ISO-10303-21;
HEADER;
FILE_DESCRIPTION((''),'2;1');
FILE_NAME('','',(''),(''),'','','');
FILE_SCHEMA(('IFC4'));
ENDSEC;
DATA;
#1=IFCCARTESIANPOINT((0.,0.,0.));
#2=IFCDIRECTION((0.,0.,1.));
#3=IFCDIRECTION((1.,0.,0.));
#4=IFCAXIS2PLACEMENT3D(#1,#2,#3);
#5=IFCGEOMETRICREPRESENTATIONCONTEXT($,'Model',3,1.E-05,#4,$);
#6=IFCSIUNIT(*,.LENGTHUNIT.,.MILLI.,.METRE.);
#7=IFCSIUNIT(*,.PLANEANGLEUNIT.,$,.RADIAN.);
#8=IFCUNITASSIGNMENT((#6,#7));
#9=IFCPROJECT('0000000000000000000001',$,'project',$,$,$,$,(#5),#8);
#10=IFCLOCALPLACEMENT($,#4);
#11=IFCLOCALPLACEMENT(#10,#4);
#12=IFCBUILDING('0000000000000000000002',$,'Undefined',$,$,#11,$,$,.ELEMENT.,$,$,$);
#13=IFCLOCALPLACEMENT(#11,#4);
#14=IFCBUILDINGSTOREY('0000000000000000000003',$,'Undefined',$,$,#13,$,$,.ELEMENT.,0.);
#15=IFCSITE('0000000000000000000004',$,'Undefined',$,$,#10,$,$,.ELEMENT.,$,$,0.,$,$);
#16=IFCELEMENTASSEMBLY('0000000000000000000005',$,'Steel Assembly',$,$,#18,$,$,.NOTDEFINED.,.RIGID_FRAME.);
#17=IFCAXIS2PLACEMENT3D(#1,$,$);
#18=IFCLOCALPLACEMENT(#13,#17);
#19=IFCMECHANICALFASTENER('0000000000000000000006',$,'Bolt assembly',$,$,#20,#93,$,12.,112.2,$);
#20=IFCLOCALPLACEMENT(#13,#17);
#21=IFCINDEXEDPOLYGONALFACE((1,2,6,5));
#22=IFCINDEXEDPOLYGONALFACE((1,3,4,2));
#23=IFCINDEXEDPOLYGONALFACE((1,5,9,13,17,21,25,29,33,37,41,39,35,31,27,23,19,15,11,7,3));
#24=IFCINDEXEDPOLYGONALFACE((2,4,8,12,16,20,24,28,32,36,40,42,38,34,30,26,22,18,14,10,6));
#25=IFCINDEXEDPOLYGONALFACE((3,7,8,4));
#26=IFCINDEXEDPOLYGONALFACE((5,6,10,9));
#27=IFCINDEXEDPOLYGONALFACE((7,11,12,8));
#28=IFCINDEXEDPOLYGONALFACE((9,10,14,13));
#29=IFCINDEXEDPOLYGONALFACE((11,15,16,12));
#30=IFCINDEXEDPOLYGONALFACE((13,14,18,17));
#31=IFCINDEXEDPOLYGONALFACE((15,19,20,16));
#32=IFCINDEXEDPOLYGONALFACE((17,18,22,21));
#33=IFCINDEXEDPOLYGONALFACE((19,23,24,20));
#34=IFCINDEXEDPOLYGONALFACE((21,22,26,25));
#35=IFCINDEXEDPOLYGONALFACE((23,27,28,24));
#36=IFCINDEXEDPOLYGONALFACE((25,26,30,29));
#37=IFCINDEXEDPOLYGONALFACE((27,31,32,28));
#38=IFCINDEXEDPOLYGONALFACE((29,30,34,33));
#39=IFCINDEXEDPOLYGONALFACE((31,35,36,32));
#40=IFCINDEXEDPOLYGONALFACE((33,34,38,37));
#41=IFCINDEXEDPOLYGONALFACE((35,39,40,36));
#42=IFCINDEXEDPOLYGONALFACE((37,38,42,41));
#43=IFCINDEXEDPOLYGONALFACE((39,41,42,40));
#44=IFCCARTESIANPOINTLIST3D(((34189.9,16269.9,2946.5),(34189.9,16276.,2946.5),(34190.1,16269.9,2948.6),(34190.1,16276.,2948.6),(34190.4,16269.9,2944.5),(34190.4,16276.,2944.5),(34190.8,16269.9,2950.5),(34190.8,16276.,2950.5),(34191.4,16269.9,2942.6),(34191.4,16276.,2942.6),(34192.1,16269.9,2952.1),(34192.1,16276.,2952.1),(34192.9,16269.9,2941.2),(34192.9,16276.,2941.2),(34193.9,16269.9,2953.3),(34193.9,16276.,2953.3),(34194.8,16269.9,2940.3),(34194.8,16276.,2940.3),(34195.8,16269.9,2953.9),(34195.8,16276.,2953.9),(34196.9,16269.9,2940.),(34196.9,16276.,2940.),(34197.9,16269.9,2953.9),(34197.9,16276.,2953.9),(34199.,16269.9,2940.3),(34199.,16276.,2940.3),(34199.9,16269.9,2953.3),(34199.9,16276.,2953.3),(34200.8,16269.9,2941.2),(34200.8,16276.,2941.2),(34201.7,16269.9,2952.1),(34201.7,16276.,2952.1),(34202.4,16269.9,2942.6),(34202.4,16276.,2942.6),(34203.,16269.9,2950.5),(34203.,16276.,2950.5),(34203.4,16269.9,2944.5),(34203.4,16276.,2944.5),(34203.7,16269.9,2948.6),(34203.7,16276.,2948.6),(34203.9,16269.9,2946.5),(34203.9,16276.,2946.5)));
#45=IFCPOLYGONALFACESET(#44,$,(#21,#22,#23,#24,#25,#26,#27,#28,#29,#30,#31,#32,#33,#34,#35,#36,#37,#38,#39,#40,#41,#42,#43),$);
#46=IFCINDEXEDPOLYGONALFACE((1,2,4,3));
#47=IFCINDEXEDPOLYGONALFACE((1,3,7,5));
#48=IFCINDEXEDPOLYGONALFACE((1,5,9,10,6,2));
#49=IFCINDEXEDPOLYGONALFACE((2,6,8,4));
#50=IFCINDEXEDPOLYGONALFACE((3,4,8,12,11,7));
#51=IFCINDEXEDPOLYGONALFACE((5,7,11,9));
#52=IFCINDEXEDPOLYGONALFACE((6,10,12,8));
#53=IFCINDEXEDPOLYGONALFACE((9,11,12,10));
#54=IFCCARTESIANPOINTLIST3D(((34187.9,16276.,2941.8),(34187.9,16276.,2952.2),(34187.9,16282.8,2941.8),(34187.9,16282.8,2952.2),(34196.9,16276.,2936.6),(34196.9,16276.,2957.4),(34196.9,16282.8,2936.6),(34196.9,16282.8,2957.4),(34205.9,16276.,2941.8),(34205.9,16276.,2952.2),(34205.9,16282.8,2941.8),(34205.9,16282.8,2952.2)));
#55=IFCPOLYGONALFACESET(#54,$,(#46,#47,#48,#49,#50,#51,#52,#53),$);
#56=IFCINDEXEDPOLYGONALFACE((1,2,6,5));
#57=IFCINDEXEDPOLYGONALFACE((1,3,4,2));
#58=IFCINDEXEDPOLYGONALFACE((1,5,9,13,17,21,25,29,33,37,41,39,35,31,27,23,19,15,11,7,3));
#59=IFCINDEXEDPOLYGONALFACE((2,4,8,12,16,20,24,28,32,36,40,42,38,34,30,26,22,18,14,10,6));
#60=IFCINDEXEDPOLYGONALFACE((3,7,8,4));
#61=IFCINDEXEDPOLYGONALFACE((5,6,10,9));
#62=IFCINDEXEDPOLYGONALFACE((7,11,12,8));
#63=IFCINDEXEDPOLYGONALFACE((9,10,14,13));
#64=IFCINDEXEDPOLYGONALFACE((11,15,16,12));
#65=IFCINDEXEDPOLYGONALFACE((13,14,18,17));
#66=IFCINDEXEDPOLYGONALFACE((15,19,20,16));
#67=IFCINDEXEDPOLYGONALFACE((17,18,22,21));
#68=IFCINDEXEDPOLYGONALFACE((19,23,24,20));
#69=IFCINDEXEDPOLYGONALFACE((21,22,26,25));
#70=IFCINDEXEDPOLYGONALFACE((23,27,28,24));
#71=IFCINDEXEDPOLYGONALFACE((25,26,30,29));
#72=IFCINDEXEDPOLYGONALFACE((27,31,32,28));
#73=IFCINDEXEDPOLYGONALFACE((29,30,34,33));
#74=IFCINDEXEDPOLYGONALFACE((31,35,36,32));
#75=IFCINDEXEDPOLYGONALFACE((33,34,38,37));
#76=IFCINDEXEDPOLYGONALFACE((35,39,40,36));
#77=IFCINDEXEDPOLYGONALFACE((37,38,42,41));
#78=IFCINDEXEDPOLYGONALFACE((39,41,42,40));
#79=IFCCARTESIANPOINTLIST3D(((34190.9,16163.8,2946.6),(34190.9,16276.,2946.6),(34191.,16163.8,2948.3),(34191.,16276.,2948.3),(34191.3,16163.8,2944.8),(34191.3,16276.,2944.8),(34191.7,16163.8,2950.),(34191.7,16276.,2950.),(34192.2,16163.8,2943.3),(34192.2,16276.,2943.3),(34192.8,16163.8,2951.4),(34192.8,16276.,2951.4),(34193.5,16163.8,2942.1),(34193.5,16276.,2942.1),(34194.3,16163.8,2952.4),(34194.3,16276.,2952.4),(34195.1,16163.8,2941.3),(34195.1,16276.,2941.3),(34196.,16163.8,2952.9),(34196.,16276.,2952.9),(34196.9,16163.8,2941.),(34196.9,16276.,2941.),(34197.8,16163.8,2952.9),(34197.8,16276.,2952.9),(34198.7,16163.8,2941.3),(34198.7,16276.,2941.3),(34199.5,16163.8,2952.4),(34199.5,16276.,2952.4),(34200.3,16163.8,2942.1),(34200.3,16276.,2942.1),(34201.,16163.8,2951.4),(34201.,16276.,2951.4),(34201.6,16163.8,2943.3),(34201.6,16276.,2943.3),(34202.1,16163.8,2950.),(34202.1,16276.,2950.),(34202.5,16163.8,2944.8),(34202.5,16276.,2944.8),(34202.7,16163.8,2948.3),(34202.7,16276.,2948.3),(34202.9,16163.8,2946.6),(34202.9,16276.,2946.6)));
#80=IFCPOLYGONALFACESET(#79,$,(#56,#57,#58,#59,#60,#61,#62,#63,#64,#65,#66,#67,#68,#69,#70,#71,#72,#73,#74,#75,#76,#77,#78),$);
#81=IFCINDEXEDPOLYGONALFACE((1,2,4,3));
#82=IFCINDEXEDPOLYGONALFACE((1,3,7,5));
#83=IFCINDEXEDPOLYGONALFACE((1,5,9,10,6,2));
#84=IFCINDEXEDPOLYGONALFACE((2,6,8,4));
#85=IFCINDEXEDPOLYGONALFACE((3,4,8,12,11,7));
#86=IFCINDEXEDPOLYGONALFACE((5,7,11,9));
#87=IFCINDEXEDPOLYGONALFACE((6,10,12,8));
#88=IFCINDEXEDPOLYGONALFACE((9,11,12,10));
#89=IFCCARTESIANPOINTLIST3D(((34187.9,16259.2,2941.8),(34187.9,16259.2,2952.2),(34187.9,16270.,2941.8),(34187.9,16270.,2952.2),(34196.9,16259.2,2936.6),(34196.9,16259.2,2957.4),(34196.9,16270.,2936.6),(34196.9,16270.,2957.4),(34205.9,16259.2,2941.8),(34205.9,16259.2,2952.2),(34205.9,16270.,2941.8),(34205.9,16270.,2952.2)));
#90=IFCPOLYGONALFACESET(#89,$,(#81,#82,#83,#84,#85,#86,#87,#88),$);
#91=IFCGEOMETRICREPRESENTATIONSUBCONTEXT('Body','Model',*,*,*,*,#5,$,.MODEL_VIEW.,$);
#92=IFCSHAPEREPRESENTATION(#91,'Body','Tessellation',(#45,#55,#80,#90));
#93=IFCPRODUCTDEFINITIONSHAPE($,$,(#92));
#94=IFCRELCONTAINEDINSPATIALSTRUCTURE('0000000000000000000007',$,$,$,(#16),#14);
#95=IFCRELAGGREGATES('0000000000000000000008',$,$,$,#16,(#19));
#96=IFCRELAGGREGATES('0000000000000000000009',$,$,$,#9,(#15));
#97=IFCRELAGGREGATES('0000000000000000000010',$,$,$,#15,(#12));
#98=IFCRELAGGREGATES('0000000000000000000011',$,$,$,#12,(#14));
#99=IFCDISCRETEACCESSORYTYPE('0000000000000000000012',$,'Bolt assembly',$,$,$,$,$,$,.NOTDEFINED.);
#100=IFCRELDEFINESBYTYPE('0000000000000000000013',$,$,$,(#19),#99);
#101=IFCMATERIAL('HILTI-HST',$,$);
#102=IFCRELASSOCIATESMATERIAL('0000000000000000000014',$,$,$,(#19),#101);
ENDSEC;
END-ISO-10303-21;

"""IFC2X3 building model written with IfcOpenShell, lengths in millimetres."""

from ifc_helpers import new_model, si_unit, frame, origin_with_axes, origin_2d_with_axis, place, context, subcontext, project, spatial, polyline, circle, outline, extrude, source, transform, mapped, material, type_object, element, aggregate, save


model = new_model("IFC2X3")

# Units and contexts
model_context = context("Model", 3, precision=1e-05, world=origin_with_axes())
body_context = subcontext(model_context, "Body", "Model", "MODEL_VIEW")
ifc_project = project(units=[si_unit("LENGTHUNIT", "METRE", prefix="MILLI"), si_unit("PLANEANGLEUNIT", "RADIAN")], contexts=[model_context])

# Site, building, storey
site_placement = place(None, origin_with_axes())
site = spatial("IfcSite", under=ifc_project, at=site_placement, Name="Undefined", CompositionType="ELEMENT", RefElevation=0.0)
building_placement = place(site_placement, origin_with_axes())
building = spatial("IfcBuilding", under=site, at=building_placement, Name="Undefined", CompositionType="ELEMENT")
storey_placement = place(building_placement, origin_with_axes())
storey = spatial("IfcBuildingStorey", under=building, at=storey_placement, Name="Undefined", CompositionType="ELEMENT", Elevation=0.0)

# Shared definitions
discrete_accessory_type_1 = type_object("IfcDiscreteAccessoryType", Name="Bolt assembly")

# Element assembly, mechanical fastener
assembly_1_placement = place(storey_placement, origin_with_axes())
assembly_1 = element("IfcElementAssembly", 1, at=assembly_1_placement, inside=storey, Name="Steel Assembly", AssemblyPlace="NOTDEFINED", PredefinedType="RIGID_FRAME")
ifc_material_1 = material(Name="HILTI-HST")
shared_shape_1 = source(origin_with_axes(), body_context, "Body", "SweptSolid", [
    extrude(circle(Radius=7.0, at=origin_2d_with_axis()), frame((0.0, 0.0, 0.0), z_axis=(0.0, 1.0, 0.0), x_axis=(1.0, 0.0, 0.0)), (0.0, 0.0, 1.0), 6.1),
    extrude(outline(polyline([(10.4, 0.0), (5.2, 9.0), (-5.2, 9.0), (-10.4, 0.0), (-5.2, -9.0), (5.2, -9.0), (10.4, 0.0)])), frame((0.0, -6.8, 0.0), z_axis=(0.0, 1.0, 0.0), x_axis=(1.0, 0.0, 0.0)), (0.0, 0.0, 1.0), 6.8),
    extrude(circle(Radius=6.0, at=origin_2d_with_axis()), frame((0.0, 0.0, 0.0), z_axis=(0.0, 1.0, 0.0), x_axis=(1.0, 0.0, 0.0)), (0.0, 0.0, 1.0), 112.2),
    extrude(outline(polyline([(10.4, 0.0), (5.2, 9.0), (-5.2, 9.0), (-10.4, 0.0), (-5.2, -9.0), (5.2, -9.0), (10.4, 0.0)])), frame((0.0, 6.0, 0.0), z_axis=(0.0, 1.0, 0.0), x_axis=(1.0, 0.0, 0.0)), (0.0, 0.0, 1.0), 10.8),
])
mechanical_fastener_1_placement = place(assembly_1_placement, frame((34196.9, 16276.0, 2947.0), z_axis=(-1.0, 0.0, 0.0), x_axis=(0.0, 0.0, -1.0)))
mechanical_fastener_1 = element("IfcMechanicalFastener", 2, at=mechanical_fastener_1_placement, type_object=discrete_accessory_type_1, material=ifc_material_1, Name="Bolt assembly", NominalDiameter=12.0, NominalLength=112.2, context=body_context, shape_type="MappedRepresentation", body=[
    mapped(shared_shape_1, transform((0.0, 0.0, 0.0))),
])
aggregate(assembly_1, [mechanical_fastener_1])

save(model, "model.ifc")
